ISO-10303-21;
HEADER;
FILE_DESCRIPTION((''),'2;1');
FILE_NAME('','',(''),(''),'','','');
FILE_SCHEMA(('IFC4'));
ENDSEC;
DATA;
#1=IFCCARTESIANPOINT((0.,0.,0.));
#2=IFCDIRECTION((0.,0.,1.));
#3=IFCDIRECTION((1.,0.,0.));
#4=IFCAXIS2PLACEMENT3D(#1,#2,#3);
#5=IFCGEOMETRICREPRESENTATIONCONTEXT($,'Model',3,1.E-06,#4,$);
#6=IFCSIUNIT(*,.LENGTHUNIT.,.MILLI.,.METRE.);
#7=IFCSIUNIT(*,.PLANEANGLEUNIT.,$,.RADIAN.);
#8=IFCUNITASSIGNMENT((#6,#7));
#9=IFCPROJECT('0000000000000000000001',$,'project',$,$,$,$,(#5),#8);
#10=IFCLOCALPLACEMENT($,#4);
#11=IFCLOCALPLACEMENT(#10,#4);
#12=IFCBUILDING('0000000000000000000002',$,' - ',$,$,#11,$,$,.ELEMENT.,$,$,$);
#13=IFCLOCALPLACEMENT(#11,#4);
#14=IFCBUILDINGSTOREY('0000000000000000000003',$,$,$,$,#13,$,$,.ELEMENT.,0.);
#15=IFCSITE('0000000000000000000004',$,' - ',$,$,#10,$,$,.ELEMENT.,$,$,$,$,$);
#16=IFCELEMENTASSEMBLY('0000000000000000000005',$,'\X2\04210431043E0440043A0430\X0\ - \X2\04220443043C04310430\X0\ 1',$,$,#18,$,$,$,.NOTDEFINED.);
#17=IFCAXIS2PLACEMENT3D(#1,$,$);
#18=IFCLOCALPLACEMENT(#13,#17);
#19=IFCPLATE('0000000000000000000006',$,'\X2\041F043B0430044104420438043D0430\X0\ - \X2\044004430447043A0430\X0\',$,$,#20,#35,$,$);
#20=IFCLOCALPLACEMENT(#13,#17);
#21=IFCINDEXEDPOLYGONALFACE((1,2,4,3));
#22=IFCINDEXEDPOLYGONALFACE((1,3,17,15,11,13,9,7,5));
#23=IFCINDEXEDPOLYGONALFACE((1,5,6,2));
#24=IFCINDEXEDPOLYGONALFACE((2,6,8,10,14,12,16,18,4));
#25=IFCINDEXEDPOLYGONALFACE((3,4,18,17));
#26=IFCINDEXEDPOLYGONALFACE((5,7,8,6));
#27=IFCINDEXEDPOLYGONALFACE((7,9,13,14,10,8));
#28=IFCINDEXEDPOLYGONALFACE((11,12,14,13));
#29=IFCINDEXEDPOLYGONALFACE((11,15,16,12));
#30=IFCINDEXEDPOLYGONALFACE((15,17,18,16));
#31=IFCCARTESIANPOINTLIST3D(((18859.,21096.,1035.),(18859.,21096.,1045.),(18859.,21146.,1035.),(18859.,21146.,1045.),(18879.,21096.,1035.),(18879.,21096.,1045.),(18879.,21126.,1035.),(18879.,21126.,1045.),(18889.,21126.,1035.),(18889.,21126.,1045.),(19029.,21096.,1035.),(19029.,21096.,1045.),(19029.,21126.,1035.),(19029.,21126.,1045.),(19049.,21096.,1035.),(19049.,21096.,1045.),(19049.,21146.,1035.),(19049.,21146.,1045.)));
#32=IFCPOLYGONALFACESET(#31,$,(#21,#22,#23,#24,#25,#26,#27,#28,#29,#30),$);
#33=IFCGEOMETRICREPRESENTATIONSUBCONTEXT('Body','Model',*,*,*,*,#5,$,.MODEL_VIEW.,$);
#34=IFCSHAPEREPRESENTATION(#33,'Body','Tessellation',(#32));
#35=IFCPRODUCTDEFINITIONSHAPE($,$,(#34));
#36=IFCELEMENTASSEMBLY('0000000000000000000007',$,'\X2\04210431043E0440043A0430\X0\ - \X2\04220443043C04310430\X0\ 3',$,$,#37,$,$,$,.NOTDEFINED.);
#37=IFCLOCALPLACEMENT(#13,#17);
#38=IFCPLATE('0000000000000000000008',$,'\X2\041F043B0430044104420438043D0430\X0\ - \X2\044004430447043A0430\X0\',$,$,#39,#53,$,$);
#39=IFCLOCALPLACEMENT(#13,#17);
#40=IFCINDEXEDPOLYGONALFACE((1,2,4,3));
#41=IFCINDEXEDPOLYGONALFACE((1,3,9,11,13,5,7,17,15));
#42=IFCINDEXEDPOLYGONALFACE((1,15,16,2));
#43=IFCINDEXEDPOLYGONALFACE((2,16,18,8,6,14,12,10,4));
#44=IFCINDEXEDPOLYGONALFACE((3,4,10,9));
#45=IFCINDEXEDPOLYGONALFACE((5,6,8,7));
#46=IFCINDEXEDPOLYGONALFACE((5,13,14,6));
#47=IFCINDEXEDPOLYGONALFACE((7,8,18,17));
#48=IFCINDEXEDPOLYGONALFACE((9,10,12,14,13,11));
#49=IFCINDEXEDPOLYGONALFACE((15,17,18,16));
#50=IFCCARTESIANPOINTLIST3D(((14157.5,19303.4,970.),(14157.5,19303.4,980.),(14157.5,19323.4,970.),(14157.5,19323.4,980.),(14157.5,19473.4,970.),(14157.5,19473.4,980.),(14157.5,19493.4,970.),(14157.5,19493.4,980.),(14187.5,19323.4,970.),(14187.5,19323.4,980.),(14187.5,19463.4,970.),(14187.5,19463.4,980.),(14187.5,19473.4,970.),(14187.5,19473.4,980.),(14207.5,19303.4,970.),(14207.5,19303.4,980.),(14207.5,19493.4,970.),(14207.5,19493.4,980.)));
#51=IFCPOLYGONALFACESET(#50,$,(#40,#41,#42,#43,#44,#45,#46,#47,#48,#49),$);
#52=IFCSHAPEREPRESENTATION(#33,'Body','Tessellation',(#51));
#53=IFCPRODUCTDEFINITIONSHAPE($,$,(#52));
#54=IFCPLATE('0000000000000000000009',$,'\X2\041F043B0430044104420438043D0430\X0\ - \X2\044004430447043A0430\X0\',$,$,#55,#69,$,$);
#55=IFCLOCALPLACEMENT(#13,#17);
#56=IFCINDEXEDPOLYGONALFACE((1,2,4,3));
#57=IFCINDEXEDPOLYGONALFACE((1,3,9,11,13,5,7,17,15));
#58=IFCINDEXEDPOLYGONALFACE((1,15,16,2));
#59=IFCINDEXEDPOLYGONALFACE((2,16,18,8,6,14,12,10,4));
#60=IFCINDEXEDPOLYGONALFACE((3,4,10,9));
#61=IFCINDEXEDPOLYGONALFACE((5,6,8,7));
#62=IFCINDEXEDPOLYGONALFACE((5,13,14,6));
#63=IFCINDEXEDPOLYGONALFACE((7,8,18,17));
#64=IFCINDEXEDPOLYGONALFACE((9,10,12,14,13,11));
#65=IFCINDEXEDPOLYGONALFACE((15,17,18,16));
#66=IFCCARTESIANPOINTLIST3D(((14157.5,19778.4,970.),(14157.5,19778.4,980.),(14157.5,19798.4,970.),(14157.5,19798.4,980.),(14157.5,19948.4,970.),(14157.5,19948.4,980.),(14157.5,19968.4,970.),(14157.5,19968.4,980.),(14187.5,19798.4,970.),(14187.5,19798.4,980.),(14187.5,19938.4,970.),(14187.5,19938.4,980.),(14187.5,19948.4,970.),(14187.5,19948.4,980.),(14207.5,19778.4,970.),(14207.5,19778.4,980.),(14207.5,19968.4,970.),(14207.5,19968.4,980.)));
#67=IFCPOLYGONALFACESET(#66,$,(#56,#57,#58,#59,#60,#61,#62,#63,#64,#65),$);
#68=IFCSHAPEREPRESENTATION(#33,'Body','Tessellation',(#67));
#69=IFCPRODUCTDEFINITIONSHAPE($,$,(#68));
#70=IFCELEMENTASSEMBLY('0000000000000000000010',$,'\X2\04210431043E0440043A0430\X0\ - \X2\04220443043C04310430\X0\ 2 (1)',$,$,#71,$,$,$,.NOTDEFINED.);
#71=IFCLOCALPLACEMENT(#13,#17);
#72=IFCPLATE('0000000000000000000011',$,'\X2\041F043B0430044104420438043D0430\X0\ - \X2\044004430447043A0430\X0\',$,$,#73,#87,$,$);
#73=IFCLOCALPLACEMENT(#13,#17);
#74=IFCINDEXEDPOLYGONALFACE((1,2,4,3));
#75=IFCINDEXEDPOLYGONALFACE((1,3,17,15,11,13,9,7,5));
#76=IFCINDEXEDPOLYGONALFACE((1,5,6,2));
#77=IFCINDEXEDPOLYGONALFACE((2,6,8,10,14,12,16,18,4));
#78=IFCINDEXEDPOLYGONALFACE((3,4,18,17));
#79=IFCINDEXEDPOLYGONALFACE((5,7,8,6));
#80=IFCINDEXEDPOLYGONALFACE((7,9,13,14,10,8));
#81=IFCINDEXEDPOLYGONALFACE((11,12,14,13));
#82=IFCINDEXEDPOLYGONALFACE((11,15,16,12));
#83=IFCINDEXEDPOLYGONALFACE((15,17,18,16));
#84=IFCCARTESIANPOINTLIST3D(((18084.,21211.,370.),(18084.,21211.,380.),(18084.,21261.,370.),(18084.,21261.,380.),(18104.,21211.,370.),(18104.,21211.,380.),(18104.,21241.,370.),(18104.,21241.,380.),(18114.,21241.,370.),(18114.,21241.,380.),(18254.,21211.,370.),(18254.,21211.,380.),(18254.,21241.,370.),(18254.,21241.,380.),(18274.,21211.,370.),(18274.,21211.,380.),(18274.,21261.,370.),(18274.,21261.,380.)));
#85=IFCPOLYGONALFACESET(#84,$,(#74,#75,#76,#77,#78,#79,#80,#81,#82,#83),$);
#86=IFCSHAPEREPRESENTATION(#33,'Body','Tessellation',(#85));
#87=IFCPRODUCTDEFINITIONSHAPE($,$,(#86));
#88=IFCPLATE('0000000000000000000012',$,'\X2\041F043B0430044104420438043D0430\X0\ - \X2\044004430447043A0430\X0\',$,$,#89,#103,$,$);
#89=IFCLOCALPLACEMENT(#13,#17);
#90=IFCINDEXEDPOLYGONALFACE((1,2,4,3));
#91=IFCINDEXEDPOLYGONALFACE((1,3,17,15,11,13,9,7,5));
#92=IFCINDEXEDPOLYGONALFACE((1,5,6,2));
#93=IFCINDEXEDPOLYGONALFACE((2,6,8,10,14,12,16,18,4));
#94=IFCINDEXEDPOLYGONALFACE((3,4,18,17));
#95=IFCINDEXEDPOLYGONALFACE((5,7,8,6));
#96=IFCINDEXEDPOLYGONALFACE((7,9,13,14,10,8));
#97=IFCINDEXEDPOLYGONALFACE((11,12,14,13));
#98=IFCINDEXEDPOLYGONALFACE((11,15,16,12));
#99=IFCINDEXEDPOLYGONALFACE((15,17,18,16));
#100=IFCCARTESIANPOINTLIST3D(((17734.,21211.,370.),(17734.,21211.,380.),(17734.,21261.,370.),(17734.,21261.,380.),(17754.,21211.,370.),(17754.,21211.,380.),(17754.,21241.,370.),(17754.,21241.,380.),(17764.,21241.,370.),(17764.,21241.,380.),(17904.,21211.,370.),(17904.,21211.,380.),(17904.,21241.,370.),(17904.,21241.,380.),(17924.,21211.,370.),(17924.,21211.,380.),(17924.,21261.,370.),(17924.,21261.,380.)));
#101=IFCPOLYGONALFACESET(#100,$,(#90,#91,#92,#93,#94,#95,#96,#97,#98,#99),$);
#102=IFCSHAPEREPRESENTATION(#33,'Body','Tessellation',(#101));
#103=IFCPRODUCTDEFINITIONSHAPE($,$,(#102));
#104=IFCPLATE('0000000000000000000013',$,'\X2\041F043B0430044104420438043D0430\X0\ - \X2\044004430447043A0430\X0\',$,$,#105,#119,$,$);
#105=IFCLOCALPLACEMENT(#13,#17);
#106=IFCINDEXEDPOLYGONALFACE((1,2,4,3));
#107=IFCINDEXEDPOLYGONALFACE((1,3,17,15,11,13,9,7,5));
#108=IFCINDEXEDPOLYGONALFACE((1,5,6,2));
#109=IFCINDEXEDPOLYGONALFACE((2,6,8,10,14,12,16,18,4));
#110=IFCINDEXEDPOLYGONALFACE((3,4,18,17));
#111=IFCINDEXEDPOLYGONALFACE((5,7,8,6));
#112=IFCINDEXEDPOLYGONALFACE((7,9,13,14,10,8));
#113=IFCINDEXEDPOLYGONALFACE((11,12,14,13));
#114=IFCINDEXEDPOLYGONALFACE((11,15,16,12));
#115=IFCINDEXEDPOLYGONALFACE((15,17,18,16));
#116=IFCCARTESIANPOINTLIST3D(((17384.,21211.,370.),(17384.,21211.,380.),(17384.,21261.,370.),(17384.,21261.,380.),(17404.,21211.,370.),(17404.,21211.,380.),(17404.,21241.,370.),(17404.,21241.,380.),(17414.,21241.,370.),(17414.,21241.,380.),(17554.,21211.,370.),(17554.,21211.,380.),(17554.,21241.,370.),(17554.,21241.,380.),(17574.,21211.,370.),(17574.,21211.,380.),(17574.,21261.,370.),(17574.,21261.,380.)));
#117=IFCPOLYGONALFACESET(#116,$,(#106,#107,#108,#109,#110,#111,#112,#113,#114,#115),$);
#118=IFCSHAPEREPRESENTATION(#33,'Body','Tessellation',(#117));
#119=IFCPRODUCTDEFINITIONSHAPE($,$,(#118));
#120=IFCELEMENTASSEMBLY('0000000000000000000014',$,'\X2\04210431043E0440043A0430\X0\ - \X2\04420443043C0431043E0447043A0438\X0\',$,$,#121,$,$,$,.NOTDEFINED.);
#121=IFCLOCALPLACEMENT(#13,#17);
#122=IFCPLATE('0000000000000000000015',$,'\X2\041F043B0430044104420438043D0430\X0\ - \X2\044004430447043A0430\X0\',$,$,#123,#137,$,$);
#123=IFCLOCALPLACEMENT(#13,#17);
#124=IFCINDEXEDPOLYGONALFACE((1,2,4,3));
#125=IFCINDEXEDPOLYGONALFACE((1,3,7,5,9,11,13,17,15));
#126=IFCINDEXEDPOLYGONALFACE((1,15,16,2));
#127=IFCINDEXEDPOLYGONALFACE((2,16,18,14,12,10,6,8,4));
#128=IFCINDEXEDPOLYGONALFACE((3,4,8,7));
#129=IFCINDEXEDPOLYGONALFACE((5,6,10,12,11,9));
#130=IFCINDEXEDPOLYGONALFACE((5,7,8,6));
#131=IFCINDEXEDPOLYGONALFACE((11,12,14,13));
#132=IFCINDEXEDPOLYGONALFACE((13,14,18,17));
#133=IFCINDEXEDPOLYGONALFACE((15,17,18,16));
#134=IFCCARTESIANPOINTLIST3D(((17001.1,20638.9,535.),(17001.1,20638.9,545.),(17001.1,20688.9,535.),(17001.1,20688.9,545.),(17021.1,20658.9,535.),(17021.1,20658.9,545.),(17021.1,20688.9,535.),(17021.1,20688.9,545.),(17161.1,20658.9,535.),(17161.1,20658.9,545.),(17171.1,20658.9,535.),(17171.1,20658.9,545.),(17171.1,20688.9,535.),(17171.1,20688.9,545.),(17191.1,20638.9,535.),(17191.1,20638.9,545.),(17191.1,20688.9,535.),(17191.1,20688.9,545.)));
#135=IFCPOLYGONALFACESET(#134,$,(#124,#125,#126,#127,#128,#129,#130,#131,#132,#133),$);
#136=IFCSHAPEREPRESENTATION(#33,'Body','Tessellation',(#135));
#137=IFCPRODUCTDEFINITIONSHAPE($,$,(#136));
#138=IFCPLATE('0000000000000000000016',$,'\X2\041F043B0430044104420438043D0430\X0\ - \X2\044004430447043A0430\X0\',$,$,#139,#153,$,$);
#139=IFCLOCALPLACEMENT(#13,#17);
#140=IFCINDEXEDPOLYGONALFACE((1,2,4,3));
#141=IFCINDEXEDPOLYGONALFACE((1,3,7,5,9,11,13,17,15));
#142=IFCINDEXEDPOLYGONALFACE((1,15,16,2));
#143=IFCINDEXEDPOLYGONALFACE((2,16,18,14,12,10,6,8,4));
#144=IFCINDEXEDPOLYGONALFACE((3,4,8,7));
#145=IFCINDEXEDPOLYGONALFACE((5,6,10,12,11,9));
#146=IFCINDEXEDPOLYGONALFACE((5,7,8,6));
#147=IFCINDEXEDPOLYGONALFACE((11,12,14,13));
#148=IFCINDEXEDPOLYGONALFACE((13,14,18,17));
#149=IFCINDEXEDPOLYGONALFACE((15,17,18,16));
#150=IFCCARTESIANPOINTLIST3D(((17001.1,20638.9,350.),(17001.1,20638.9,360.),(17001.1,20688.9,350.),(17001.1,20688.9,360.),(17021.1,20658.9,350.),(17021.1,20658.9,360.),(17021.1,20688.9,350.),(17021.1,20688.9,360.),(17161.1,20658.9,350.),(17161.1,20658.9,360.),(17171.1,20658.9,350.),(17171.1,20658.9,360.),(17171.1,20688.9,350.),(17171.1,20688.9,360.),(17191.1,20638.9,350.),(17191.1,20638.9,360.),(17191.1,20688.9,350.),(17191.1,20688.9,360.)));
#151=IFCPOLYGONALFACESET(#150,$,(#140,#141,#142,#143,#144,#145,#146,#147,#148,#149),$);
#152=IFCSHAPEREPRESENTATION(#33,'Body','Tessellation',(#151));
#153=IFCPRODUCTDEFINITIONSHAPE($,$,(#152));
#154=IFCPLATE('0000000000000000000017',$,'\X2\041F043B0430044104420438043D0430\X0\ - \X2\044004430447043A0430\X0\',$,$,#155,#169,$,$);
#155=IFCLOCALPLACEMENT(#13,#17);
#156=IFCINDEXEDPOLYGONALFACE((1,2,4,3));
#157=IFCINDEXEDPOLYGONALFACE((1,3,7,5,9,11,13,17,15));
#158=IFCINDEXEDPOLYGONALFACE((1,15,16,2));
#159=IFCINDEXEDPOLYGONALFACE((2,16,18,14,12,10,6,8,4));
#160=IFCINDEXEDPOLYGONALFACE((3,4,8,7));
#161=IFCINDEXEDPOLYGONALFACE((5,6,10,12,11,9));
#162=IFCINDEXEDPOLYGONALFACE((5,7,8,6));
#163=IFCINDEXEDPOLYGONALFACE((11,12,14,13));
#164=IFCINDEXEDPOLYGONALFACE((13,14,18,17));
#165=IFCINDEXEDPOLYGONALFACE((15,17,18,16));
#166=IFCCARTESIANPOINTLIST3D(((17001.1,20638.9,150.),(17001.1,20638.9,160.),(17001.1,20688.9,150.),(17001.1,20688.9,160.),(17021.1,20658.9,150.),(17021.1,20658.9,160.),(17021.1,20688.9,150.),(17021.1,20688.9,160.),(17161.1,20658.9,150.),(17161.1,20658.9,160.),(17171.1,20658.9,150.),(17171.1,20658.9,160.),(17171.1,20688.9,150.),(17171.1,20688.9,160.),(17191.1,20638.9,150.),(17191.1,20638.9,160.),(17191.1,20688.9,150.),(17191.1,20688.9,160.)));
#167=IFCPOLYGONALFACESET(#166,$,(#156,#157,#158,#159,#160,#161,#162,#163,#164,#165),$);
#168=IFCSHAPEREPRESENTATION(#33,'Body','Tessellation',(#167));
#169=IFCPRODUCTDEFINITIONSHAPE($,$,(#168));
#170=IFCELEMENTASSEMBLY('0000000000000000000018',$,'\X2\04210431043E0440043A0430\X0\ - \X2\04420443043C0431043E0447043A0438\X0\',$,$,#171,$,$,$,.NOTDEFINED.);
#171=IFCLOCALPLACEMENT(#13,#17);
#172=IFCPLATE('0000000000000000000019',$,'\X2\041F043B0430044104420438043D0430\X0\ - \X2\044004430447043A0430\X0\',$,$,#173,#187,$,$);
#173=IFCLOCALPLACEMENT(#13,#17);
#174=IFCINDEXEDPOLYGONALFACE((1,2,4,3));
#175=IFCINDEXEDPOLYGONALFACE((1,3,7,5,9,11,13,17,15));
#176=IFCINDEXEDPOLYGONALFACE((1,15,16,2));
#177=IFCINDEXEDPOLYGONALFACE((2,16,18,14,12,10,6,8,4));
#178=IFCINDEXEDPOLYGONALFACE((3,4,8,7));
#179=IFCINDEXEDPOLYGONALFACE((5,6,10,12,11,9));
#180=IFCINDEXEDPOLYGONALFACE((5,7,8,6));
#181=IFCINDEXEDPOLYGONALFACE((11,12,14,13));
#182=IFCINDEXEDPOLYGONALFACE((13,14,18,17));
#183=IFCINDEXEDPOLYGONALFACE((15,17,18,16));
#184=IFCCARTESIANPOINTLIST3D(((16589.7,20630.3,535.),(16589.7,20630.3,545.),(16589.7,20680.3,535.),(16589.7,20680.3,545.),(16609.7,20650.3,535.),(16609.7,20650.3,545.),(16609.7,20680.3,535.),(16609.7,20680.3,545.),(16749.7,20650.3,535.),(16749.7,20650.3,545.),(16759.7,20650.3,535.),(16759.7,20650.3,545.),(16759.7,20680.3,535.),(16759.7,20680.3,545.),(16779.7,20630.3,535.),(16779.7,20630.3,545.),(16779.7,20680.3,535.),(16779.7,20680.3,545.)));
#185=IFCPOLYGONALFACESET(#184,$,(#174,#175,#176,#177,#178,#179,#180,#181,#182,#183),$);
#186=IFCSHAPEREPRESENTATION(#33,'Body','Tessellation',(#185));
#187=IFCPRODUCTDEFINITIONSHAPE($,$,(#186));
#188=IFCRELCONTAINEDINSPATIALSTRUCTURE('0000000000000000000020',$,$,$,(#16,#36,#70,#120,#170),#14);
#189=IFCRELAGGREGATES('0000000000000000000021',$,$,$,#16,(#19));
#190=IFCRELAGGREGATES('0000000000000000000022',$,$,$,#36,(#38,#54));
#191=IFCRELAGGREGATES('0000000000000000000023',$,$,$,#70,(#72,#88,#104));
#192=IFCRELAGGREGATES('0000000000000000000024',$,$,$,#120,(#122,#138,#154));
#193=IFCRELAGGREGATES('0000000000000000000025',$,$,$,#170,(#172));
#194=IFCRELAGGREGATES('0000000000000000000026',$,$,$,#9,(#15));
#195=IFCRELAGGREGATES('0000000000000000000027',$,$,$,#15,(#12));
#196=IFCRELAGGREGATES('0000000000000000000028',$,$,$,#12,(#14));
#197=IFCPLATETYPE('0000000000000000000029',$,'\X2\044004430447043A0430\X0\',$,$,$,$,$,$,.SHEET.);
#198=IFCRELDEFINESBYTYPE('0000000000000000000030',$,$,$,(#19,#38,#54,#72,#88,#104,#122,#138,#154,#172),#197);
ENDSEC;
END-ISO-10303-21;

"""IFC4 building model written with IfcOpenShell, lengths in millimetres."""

from ifc_helpers import new_model, si_unit, frame, origin_with_axes, place, context, subcontext, project, spatial, line, indexed_curve, outline, extrude, source, transform, mapped, type_object, element, aggregate, save


model = new_model("IFC4")

# Units and contexts
model_context = context("Model", 3, precision=1e-06, world=origin_with_axes())
body_context = subcontext(model_context, "Body", "Model", "MODEL_VIEW")
ifc_project = project(units=[si_unit("LENGTHUNIT", "METRE", prefix="MILLI"), si_unit("PLANEANGLEUNIT", "RADIAN")], contexts=[model_context])

# Site, building, storey
site_placement = place(None, origin_with_axes())
site = spatial("IfcSite", under=ifc_project, at=site_placement, Name=" - ", CompositionType="ELEMENT")
building_placement = place(site_placement, origin_with_axes())
building = spatial("IfcBuilding", under=site, at=building_placement, Name=" - ", CompositionType="ELEMENT")
storey_placement = place(building_placement, origin_with_axes())
storey = spatial("IfcBuildingStorey", under=building, at=storey_placement, CompositionType="ELEMENT", Elevation=0.0)

# Shared definitions
plate_type = type_object("IfcPlateType", Name="ручка", PredefinedType="SHEET")
shared_shape_1 = source(origin_with_axes(), body_context, "Body", "SweptSolid", [
    extrude(outline(indexed_curve([(-95.0, -25.0), (-75.0, -25.0), (-75.0, 5.0), (-65.0, 5.0), (75.0, 5.0), (75.0, -25.0), (95.0, -25.0), (95.0, 25.0), (-95.0, 25.0)], segments=[line(1, 2), line(2, 3), line(3, 4), line(4, 5), line(5, 6), line(6, 7), line(7, 8), line(8, 9), line(9, 1)])), origin_with_axes(), (0.0, 0.0, 1.0), 10.0),
])

# Element assembly, plate
assembly_1_placement = place(storey_placement, frame((19554.0, 21081.0, 0.0), z_axis=(0.0, 0.0, 1.0), x_axis=(-1.0, 0.0, 0.0)))
assembly_1 = element("IfcElementAssembly", 1, at=assembly_1_placement, inside=storey, Name="Сборка - Тумба 1", PredefinedType="NOTDEFINED")
plate_1_placement = place(assembly_1_placement, frame((600.0, -40.0, 1035.0), z_axis=(0.0, 0.0, 1.0), x_axis=(-1.0, 0.0, 0.0)))
plate_1 = element("IfcPlate", 2, at=plate_1_placement, type_object=plate_type, Name="Пластина - ручка", context=body_context, shape_type="MappedRepresentation", body=[
    mapped(shared_shape_1, transform((0.0, 0.0, 0.0), x_axis=(1.0, 0.0, 0.0), y_axis=(0.0, 1.0, 0.0), z_axis=(0.0, 0.0, 1.0), scale=1.0)),
])
aggregate(assembly_1, [plate_1])

# Element assemblies, plates
assembly_2_placement = place(storey_placement, frame((13967.5, 19398.4, 0.0), z_axis=(0.0, 0.0, 1.0), x_axis=(0.0, 1.0, 0.0)))
assembly_2 = element("IfcElementAssembly", 3, at=assembly_2_placement, inside=storey, Name="Сборка - Тумба 3", PredefinedType="NOTDEFINED")
plate_2_placement = place(assembly_2_placement, frame((0.0, -215.0, 970.0), z_axis=(0.0, 0.0, 1.0), x_axis=(-1.0, 0.0, 0.0)))
plate_2 = element("IfcPlate", 4, at=plate_2_placement, type_object=plate_type, Name="Пластина - ручка", context=body_context, shape_type="MappedRepresentation", body=[
    mapped(shared_shape_1, transform((0.0, 0.0, 0.0), x_axis=(1.0, 0.0, 0.0), y_axis=(0.0, 1.0, 0.0), z_axis=(0.0, 0.0, 1.0), scale=1.0)),
])
plate_3_placement = place(assembly_2_placement, frame((475.0, -215.0, 970.0), z_axis=(0.0, 0.0, 1.0), x_axis=(-1.0, 0.0, 0.0)))
plate_3 = element("IfcPlate", 5, at=plate_3_placement, type_object=plate_type, Name="Пластина - ручка", context=body_context, shape_type="MappedRepresentation", body=[
    mapped(shared_shape_1, transform((0.0, 0.0, 0.0), x_axis=(1.0, 0.0, 0.0), y_axis=(0.0, 1.0, 0.0), z_axis=(0.0, 0.0, 1.0), scale=1.0)),
])
aggregate(assembly_2, [plate_2, plate_3])
assembly_3_placement = place(storey_placement, frame((17654.0, 20996.0, 0.0), z_axis=(0.0, 0.0, 1.0), x_axis=(-1.0, 0.0, 0.0)))
assembly_3 = element("IfcElementAssembly", 6, at=assembly_3_placement, inside=storey, Name="Сборка - Тумба 2 (1)", PredefinedType="NOTDEFINED")
plate_4_placement = place(assembly_3_placement, frame((-525.0, -240.0, 370.0), z_axis=(0.0, 0.0, 1.0), x_axis=(-1.0, 0.0, 0.0)))
plate_4 = element("IfcPlate", 7, at=plate_4_placement, type_object=plate_type, Name="Пластина - ручка", context=body_context, shape_type="MappedRepresentation", body=[
    mapped(shared_shape_1, transform((0.0, 0.0, 0.0), x_axis=(1.0, 0.0, 0.0), y_axis=(0.0, 1.0, 0.0), z_axis=(0.0, 0.0, 1.0), scale=1.0)),
])
plate_5_placement = place(assembly_3_placement, frame((-175.0, -240.0, 370.0), z_axis=(0.0, 0.0, 1.0), x_axis=(-1.0, 0.0, 0.0)))
plate_5 = element("IfcPlate", 8, at=plate_5_placement, type_object=plate_type, Name="Пластина - ручка", context=body_context, shape_type="MappedRepresentation", body=[
    mapped(shared_shape_1, transform((0.0, 0.0, 0.0), x_axis=(1.0, 0.0, 0.0), y_axis=(0.0, 1.0, 0.0), z_axis=(0.0, 0.0, 1.0), scale=1.0)),
])
plate_6_placement = place(assembly_3_placement, frame((175.0, -240.0, 370.0), z_axis=(0.0, 0.0, 1.0), x_axis=(-1.0, 0.0, 0.0)))
plate_6 = element("IfcPlate", 9, at=plate_6_placement, type_object=plate_type, Name="Пластина - ручка", context=body_context, shape_type="MappedRepresentation", body=[
    mapped(shared_shape_1, transform((0.0, 0.0, 0.0), x_axis=(1.0, 0.0, 0.0), y_axis=(0.0, 1.0, 0.0), z_axis=(0.0, 0.0, 1.0), scale=1.0)),
])
aggregate(assembly_3, [plate_4, plate_5, plate_6])
assembly_4_placement = place(storey_placement, frame((16896.1, 20688.9, 0.0), z_axis=(0.0, 0.0, 1.0), x_axis=(1.0, 0.0, 0.0)))
assembly_4 = element("IfcElementAssembly", 10, at=assembly_4_placement, inside=storey, Name="Сборка - тумбочки", PredefinedType="NOTDEFINED")
plate_7_placement = place(assembly_4_placement, frame((200.0, -25.0, 535.0), z_axis=(0.0, 0.0, 1.0), x_axis=(-1.0, 0.0, 0.0)))
plate_7 = element("IfcPlate", 11, at=plate_7_placement, type_object=plate_type, Name="Пластина - ручка", context=body_context, shape_type="MappedRepresentation", body=[
    mapped(shared_shape_1, transform((0.0, 0.0, 0.0), x_axis=(1.0, 0.0, 0.0), y_axis=(0.0, 1.0, 0.0), z_axis=(0.0, 0.0, 1.0), scale=1.0)),
])
plate_8_placement = place(assembly_4_placement, frame((200.0, -25.0, 350.0), z_axis=(0.0, 0.0, 1.0), x_axis=(-1.0, 0.0, 0.0)))
plate_8 = element("IfcPlate", 12, at=plate_8_placement, type_object=plate_type, Name="Пластина - ручка", context=body_context, shape_type="MappedRepresentation", body=[
    mapped(shared_shape_1, transform((0.0, 0.0, 0.0), x_axis=(1.0, 0.0, 0.0), y_axis=(0.0, 1.0, 0.0), z_axis=(0.0, 0.0, 1.0), scale=1.0)),
])
plate_9_placement = place(assembly_4_placement, frame((200.0, -25.0, 150.0), z_axis=(0.0, 0.0, 1.0), x_axis=(-1.0, 0.0, 0.0)))
plate_9 = element("IfcPlate", 13, at=plate_9_placement, type_object=plate_type, Name="Пластина - ручка", context=body_context, shape_type="MappedRepresentation", body=[
    mapped(shared_shape_1, transform((0.0, 0.0, 0.0), x_axis=(1.0, 0.0, 0.0), y_axis=(0.0, 1.0, 0.0), z_axis=(0.0, 0.0, 1.0), scale=1.0)),
])
aggregate(assembly_4, [plate_7, plate_8, plate_9])
assembly_5_placement = place(storey_placement, frame((16484.7, 20680.3, 0.0), z_axis=(0.0, 0.0, 1.0), x_axis=(1.0, 0.0, 0.0)))
assembly_5 = element("IfcElementAssembly", 14, at=assembly_5_placement, inside=storey, Name="Сборка - тумбочки", PredefinedType="NOTDEFINED")
plate_10_placement = place(assembly_5_placement, frame((200.0, -25.0, 535.0), z_axis=(0.0, 0.0, 1.0), x_axis=(-1.0, 0.0, 0.0)))
plate_10 = element("IfcPlate", 15, at=plate_10_placement, type_object=plate_type, Name="Пластина - ручка", context=body_context, shape_type="MappedRepresentation", body=[
    mapped(shared_shape_1, transform((0.0, 0.0, 0.0), x_axis=(1.0, 0.0, 0.0), y_axis=(0.0, 1.0, 0.0), z_axis=(0.0, 0.0, 1.0), scale=1.0)),
])
aggregate(assembly_5, [plate_10])

save(model, "model.ifc")
